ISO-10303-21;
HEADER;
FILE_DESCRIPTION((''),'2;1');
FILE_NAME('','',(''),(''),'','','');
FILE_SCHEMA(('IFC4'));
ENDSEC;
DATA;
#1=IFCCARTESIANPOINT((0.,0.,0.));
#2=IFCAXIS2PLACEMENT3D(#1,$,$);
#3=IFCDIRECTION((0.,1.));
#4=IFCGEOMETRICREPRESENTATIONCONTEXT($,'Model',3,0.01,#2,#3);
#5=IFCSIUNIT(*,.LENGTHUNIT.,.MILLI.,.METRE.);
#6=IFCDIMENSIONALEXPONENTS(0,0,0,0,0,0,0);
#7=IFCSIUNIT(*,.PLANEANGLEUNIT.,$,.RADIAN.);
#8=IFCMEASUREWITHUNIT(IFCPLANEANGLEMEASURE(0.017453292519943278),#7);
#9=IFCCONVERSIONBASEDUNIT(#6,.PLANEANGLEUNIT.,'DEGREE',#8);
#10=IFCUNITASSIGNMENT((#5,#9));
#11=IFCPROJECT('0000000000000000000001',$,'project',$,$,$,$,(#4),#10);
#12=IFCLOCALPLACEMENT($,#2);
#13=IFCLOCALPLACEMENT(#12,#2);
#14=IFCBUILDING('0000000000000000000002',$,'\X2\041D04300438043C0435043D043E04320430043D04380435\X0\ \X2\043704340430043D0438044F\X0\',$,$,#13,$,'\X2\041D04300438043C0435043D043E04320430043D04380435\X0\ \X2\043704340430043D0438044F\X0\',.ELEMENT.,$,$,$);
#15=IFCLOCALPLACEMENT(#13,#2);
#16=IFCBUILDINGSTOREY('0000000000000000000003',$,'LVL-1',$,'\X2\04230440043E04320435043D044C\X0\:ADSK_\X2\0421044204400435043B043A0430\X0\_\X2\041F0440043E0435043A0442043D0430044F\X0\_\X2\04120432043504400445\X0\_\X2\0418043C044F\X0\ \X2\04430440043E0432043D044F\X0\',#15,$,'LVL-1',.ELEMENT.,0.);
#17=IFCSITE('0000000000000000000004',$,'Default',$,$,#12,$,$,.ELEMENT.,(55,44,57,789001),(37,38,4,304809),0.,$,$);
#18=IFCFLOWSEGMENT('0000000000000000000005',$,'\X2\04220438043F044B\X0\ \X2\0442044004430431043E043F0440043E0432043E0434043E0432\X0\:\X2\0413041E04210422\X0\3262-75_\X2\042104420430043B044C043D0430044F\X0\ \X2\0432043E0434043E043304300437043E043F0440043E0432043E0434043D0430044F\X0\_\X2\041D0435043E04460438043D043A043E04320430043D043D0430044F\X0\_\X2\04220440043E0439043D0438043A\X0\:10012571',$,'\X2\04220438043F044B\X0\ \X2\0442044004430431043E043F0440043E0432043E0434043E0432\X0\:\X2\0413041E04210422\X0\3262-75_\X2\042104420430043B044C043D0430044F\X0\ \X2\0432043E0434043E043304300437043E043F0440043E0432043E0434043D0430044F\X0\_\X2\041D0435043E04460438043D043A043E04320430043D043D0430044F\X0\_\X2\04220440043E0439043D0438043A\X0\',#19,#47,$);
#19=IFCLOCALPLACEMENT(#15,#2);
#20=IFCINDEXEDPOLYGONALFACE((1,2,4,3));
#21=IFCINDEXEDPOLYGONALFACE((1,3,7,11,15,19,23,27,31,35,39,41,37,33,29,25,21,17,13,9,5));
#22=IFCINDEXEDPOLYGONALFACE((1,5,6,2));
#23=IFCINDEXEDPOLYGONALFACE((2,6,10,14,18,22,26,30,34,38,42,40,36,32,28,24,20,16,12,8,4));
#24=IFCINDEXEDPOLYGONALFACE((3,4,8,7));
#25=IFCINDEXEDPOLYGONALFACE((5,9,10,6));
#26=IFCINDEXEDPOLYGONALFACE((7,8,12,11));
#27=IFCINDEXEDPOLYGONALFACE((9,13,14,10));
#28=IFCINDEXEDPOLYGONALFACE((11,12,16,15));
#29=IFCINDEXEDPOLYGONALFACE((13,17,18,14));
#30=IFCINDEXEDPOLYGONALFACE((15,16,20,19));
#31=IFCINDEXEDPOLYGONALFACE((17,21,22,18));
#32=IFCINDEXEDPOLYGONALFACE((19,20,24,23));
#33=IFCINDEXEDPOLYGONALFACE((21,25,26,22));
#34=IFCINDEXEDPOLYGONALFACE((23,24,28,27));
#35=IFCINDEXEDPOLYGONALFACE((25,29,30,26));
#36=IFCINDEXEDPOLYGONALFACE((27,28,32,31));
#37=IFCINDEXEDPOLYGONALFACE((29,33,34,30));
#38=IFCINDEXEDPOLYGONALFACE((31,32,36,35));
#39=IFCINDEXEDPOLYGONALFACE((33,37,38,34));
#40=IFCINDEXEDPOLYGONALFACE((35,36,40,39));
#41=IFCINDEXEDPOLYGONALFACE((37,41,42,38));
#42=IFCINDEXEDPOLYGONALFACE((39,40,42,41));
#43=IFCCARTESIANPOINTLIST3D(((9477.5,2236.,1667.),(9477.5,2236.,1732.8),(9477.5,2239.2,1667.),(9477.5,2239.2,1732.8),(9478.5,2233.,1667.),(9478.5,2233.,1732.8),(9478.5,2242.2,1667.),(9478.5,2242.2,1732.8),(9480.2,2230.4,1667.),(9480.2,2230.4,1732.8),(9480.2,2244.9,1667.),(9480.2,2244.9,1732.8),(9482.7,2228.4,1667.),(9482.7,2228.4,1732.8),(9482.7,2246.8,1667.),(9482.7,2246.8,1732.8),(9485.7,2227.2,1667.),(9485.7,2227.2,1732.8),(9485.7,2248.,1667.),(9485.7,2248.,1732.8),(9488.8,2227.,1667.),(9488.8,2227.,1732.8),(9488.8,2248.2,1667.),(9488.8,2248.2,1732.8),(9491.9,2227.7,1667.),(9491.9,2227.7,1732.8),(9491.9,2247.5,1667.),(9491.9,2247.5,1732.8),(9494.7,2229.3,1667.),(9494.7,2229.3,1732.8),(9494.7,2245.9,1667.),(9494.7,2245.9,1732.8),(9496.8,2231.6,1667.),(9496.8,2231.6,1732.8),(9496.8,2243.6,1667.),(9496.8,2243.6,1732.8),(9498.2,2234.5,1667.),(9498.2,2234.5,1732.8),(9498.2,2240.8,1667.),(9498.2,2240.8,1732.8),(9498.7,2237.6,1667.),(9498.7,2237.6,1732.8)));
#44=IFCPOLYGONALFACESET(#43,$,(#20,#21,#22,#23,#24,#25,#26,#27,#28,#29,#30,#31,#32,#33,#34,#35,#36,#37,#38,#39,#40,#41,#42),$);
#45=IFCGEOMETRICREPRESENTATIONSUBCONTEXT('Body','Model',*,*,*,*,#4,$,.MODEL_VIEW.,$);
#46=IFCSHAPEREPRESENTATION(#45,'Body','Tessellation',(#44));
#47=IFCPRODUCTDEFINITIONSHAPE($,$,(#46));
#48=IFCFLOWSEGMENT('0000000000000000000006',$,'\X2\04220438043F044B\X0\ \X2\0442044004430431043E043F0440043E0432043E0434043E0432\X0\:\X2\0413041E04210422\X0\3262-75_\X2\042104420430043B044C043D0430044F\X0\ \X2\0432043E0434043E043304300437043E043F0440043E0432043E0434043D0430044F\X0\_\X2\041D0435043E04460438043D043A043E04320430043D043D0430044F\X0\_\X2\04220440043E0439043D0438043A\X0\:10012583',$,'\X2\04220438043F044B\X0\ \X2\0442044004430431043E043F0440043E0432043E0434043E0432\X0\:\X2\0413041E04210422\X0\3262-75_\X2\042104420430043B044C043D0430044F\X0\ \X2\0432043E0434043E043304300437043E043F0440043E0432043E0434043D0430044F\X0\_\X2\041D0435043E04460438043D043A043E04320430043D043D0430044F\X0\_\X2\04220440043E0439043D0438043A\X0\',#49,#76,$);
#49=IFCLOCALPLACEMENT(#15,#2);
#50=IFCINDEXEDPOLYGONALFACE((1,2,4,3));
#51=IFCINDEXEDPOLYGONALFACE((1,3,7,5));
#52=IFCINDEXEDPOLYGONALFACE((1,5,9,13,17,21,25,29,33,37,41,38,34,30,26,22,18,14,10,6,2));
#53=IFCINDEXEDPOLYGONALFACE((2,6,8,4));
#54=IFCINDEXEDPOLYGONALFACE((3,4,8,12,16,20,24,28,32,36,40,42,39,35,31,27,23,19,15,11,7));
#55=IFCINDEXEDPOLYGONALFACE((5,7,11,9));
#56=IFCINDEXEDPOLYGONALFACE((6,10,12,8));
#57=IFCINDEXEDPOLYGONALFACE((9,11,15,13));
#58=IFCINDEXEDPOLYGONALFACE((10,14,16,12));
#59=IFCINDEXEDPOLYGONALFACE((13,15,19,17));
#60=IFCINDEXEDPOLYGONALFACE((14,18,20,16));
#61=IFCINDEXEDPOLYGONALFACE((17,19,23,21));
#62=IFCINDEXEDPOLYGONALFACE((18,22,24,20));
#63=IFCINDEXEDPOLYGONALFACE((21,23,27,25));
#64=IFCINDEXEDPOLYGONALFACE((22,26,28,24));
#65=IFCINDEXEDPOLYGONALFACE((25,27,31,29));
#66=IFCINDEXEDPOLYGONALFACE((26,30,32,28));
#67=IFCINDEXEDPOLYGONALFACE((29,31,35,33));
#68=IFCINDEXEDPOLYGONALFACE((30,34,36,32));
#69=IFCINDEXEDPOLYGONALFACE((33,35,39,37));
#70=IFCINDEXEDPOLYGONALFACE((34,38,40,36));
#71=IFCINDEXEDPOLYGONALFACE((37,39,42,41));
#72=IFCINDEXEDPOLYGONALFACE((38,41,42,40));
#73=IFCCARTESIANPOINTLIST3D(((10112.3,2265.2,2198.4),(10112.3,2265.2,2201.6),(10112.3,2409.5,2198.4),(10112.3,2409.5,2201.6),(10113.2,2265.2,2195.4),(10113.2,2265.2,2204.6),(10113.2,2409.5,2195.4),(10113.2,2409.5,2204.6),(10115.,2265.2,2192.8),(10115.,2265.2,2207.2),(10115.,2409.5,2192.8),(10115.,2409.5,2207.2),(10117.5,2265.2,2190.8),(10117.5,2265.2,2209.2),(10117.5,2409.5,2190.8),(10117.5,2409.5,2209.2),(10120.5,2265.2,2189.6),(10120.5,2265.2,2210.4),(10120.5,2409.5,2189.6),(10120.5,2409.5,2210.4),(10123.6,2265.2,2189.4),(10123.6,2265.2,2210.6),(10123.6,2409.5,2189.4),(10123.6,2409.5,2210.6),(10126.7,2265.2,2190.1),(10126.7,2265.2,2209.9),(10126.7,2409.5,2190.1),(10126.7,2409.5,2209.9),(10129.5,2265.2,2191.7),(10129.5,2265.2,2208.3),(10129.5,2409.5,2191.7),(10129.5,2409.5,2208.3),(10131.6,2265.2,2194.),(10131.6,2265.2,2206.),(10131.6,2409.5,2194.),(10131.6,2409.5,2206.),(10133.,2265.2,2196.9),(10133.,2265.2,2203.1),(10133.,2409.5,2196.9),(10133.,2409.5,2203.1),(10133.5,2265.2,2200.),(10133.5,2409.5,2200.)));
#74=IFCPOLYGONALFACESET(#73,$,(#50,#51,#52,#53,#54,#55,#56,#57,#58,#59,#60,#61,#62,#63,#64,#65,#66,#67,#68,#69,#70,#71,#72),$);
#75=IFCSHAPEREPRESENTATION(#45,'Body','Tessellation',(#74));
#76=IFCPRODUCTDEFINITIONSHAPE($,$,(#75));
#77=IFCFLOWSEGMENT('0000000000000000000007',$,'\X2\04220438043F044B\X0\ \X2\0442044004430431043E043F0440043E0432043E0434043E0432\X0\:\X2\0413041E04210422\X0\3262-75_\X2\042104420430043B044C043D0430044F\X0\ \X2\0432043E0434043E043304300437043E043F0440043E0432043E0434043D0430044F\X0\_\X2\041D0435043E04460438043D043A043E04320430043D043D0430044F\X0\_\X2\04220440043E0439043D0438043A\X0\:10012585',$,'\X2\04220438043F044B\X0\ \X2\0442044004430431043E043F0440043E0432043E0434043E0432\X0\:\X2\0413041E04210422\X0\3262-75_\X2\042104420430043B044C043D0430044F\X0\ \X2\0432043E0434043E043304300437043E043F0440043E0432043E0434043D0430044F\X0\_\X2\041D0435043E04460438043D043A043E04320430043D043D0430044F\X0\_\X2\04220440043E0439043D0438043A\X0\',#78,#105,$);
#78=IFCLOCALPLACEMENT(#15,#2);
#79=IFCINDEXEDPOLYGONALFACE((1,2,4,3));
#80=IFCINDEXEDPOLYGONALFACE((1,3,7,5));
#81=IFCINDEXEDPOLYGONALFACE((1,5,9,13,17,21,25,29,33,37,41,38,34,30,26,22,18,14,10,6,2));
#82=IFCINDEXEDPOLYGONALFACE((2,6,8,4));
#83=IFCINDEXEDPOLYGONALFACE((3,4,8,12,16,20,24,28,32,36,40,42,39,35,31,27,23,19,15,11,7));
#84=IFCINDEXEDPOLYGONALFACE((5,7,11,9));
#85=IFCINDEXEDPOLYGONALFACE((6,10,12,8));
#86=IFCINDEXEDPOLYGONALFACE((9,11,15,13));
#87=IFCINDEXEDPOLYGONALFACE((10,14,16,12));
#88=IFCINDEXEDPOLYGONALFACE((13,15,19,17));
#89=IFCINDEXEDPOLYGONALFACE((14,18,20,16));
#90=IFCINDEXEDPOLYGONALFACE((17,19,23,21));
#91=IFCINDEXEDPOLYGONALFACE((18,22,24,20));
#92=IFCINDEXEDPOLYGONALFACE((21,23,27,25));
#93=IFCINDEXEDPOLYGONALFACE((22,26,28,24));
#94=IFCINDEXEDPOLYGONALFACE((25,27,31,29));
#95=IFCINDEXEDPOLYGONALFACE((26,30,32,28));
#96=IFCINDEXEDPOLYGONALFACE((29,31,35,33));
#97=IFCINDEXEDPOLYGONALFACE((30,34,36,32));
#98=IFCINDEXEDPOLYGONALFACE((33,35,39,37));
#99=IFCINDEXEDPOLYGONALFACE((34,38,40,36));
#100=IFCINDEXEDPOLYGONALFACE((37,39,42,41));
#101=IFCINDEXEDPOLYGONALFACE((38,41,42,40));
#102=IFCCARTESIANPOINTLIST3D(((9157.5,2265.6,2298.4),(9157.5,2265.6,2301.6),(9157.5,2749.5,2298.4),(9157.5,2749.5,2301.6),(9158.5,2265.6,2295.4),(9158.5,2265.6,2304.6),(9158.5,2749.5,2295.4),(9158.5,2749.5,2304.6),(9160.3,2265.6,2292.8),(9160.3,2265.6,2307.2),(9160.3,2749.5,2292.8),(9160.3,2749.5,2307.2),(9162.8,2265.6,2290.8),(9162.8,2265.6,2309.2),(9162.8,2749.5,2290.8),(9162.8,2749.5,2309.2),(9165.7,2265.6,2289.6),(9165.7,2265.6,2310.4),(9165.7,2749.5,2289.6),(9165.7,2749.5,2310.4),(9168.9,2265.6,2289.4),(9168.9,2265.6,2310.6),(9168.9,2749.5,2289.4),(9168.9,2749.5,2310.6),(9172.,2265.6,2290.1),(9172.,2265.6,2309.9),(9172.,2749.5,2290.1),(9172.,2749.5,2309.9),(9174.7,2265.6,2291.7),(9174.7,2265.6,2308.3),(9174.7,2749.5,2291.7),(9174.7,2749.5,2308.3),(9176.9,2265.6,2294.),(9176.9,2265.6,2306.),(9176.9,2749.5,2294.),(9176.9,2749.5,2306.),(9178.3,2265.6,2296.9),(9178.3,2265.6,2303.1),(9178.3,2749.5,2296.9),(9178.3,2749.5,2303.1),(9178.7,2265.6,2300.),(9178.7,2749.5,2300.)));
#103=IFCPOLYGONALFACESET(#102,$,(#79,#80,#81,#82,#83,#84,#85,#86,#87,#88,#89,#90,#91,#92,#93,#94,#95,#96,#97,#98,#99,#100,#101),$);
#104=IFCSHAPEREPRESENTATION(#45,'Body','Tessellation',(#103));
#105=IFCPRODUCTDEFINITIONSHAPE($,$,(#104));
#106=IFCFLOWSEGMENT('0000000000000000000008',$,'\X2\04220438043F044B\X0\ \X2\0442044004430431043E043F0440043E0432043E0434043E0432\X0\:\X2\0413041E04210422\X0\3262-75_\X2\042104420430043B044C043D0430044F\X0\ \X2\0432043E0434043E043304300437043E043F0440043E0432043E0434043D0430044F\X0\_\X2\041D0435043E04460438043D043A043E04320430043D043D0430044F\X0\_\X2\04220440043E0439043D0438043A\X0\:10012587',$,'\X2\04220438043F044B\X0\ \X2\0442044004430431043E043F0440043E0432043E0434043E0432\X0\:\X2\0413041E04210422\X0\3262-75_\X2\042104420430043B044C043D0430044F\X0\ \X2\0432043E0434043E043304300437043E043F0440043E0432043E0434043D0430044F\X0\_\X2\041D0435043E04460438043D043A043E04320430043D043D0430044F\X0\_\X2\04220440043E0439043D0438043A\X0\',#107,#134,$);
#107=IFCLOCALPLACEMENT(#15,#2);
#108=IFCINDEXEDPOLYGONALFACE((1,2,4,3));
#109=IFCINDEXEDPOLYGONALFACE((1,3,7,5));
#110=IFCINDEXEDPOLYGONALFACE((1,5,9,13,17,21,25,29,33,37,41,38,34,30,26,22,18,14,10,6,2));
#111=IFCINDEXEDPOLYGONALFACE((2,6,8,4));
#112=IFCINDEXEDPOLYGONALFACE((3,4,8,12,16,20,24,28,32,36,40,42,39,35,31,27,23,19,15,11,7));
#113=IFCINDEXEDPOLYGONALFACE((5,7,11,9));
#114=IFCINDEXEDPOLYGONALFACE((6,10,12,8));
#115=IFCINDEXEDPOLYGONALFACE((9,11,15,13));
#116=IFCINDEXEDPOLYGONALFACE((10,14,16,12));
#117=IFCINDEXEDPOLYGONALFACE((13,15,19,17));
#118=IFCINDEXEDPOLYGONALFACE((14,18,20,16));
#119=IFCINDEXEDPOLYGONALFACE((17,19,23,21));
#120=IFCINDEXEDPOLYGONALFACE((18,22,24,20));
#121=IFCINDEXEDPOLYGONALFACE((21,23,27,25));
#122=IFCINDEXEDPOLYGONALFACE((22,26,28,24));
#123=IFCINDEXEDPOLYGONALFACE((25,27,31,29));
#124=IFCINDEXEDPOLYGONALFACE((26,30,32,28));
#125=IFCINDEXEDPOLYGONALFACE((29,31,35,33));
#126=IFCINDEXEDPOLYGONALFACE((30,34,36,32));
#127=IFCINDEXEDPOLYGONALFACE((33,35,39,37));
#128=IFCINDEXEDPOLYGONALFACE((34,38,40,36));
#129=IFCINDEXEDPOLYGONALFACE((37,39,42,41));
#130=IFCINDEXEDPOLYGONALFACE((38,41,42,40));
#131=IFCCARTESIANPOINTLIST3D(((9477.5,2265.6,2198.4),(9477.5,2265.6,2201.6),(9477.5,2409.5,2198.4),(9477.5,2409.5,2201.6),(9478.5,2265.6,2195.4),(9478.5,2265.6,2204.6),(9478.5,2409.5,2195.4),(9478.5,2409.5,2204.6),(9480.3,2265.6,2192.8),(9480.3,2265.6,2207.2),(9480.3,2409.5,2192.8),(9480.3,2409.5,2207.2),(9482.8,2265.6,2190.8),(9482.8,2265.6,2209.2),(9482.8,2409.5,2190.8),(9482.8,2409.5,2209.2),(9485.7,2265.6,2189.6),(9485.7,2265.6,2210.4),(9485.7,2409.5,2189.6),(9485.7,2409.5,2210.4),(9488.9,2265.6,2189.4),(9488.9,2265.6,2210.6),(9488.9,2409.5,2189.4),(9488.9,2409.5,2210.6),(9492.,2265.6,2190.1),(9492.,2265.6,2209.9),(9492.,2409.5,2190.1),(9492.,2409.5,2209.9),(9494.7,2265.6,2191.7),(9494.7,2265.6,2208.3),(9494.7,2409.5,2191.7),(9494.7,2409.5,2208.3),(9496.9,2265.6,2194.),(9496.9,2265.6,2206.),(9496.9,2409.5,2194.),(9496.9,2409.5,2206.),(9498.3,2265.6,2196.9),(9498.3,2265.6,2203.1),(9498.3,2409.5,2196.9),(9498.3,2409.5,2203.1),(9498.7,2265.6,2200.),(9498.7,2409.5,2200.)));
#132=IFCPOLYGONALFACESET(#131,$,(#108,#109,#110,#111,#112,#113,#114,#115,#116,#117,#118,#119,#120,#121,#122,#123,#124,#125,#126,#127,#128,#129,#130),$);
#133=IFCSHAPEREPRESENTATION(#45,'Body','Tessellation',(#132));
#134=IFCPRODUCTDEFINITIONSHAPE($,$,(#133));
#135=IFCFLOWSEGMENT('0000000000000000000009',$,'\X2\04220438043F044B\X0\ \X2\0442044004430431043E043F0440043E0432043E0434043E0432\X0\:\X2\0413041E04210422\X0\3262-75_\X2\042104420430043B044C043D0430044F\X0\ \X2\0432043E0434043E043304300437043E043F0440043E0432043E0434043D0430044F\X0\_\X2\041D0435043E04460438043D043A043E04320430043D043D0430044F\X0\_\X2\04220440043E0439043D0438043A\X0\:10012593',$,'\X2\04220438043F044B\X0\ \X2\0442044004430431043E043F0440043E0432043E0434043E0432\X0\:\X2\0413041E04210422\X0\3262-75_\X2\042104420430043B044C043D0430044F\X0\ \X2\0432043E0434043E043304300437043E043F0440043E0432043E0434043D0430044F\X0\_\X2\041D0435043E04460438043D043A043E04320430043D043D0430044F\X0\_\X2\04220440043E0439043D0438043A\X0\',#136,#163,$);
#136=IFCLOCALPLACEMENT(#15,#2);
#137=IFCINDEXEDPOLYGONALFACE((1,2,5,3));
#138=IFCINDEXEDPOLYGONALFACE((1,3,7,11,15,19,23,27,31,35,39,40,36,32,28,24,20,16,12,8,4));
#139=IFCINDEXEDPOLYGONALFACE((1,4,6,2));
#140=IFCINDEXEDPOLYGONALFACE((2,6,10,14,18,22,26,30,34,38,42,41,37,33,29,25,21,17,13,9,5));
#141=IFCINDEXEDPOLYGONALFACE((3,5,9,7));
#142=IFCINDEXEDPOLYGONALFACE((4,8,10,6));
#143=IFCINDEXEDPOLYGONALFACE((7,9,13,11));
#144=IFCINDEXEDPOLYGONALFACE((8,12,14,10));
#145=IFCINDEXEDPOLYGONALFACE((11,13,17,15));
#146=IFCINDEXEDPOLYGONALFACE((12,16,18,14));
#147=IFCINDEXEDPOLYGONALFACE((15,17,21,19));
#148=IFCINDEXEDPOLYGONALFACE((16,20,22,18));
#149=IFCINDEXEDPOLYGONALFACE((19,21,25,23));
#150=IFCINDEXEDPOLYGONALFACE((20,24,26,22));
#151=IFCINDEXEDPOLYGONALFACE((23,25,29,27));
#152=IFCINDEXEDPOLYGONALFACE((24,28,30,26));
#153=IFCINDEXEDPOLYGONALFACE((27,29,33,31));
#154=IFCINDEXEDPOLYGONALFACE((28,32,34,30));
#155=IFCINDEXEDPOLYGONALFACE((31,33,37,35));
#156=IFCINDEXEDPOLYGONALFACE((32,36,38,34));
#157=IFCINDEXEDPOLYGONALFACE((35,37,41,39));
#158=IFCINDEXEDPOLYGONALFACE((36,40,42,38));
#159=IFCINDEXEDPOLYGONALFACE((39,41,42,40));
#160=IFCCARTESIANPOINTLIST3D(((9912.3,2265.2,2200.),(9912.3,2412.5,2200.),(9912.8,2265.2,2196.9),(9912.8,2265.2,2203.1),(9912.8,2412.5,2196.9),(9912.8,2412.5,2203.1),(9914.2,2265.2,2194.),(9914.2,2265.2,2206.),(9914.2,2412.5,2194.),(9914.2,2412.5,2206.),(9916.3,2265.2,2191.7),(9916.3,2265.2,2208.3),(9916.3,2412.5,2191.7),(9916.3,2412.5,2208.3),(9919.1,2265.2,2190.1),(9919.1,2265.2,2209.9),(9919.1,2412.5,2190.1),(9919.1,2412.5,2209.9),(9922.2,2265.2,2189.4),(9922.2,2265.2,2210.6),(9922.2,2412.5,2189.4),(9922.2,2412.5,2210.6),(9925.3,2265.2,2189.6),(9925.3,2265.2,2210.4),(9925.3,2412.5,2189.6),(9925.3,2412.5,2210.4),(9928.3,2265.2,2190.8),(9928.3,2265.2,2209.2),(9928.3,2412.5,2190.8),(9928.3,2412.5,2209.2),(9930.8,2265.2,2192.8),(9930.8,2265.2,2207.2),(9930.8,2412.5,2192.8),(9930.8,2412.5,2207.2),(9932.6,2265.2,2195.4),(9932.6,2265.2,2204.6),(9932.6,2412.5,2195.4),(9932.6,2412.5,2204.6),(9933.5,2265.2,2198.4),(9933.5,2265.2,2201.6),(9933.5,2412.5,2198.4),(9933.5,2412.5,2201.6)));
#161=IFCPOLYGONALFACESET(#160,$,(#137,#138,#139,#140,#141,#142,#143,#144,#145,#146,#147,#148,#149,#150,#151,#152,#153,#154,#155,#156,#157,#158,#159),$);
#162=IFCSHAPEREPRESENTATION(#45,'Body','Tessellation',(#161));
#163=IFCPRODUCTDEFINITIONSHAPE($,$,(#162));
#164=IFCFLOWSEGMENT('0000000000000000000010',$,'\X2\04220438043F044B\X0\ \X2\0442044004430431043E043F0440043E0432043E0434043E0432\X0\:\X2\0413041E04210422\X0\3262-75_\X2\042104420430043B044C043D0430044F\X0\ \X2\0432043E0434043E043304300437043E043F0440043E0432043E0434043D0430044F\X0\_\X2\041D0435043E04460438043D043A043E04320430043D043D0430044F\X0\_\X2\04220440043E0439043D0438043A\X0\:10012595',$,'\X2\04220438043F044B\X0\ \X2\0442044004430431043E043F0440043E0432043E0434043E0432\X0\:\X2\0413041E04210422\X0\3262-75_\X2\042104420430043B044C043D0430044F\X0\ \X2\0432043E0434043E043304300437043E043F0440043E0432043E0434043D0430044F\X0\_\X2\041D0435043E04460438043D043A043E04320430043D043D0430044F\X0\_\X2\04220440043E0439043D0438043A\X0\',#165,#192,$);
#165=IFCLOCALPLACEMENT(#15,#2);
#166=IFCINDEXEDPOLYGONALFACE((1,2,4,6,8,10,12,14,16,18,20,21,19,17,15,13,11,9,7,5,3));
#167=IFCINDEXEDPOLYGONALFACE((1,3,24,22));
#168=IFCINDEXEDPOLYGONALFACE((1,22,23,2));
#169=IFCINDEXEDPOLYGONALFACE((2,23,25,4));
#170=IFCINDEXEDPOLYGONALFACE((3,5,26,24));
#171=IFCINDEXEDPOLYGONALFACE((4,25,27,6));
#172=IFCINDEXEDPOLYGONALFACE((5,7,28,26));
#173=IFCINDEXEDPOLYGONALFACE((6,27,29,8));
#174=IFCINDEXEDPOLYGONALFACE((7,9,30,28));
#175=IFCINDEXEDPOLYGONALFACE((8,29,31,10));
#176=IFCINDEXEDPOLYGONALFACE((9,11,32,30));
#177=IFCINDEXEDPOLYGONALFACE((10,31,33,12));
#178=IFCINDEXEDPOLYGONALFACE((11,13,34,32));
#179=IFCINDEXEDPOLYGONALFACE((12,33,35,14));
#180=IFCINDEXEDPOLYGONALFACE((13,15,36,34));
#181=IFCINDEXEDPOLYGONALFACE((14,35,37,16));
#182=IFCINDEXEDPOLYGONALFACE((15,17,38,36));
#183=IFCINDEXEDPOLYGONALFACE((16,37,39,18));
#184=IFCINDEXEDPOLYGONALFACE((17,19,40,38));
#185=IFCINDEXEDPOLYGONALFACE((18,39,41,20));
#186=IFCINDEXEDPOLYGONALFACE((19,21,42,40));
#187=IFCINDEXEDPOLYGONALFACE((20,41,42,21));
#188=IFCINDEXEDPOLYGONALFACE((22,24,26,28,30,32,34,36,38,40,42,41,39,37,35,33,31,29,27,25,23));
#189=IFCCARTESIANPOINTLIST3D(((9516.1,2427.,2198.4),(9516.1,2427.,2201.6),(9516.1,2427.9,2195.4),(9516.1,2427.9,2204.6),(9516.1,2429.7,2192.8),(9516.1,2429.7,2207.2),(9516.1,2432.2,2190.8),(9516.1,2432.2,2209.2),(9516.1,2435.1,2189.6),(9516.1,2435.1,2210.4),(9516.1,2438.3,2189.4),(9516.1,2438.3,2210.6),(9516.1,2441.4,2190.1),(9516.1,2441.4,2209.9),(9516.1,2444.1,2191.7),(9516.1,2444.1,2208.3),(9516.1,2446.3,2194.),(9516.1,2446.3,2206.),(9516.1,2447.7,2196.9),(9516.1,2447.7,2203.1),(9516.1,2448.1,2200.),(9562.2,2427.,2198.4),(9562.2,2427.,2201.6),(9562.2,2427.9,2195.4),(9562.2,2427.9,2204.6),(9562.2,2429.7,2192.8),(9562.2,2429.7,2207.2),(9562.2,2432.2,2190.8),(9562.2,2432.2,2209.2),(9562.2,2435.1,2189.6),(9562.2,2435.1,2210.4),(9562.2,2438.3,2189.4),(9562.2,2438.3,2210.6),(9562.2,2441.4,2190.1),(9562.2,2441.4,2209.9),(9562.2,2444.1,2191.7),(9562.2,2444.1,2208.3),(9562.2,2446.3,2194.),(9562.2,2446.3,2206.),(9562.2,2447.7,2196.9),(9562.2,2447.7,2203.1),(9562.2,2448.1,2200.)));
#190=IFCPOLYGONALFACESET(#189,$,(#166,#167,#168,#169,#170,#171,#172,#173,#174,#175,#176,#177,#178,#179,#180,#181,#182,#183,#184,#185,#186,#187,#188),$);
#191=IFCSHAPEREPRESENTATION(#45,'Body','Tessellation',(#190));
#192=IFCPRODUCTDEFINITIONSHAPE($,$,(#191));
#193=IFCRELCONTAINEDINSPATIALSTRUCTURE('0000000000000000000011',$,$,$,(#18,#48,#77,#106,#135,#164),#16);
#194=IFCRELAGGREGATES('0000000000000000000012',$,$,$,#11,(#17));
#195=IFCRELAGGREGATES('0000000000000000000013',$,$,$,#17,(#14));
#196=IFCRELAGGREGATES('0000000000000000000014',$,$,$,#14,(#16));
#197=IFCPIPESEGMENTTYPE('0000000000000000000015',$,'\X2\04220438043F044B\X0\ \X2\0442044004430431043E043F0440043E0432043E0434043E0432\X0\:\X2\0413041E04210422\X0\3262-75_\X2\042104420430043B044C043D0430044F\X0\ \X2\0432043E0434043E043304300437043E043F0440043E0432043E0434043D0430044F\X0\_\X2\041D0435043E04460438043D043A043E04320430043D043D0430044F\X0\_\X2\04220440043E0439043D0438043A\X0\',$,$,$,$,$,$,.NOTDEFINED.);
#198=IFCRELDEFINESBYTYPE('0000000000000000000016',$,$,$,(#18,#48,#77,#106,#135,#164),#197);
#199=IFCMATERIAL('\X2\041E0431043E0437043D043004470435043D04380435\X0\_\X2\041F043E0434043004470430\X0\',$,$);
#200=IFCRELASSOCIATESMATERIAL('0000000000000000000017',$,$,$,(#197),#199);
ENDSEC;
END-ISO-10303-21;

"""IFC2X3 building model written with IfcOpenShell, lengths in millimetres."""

from ifc_helpers import new_model, entity, si_unit, converted_unit, direction, frame, frame_2d, origin, origin_2d_with_axis, place, context, subcontext, project, spatial, circle, extrude, material, type_object, element, save


model = new_model("IFC2X3")

# Units and contexts
model_context = context("Model", 3, precision=0.01, world=origin(), true_north=direction((0.0, 1.0)))
body_context = subcontext(model_context, "Body", "Model", "MODEL_VIEW")
ifc_project = project(units=[si_unit("LENGTHUNIT", "METRE", prefix="MILLI"), converted_unit("PLANEANGLEUNIT", "DEGREE", entity("IfcPlaneAngleMeasure", 0.017453292519943278), si_unit("PLANEANGLEUNIT", "RADIAN"), dimensions=[0, 0, 0, 0, 0, 0, 0])], contexts=[model_context])

# Site, building, storey
site_placement = place(None, origin())
site = spatial("IfcSite", under=ifc_project, at=site_placement, Name="Default", CompositionType="ELEMENT", RefLatitude=(55, 44, 57, 789001), RefLongitude=(37, 38, 4, 304809), RefElevation=0.0)
building_placement = place(site_placement, origin())
building = spatial("IfcBuilding", under=site, at=building_placement, Name="Наименование здания", LongName="Наименование здания", CompositionType="ELEMENT")
storey_placement = place(building_placement, origin())
storey = spatial("IfcBuildingStorey", under=building, at=storey_placement, Name="LVL-1", ObjectType="Уровень:ADSK_Стрелка_Проектная_Вверх_Имя уровня", LongName="LVL-1", CompositionType="ELEMENT", Elevation=0.0)

# Flow segments
ifc_material_1 = material(Name="Обозначение_Подача")
pipe_segment_type_1 = type_object("IfcPipeSegmentType", Name="Типы трубопроводов:ГОСТ3262-75_Стальная водогазопроводная_Неоцинкованная_Тройник", PredefinedType="NOTDEFINED", material=ifc_material_1)
flow_segment_1_placement = place(storey_placement, origin())
element("IfcFlowSegment", 1, at=flow_segment_1_placement, inside=storey, type_object=pipe_segment_type_1, Name="Типы трубопроводов:ГОСТ3262-75_Стальная водогазопроводная_Неоцинкованная_Тройник:10012571", ObjectType="Типы трубопроводов:ГОСТ3262-75_Стальная водогазопроводная_Неоцинкованная_Тройник", context=body_context, shape_type="SweptSolid", body=[
    extrude(circle(Radius=10.7, at=origin_2d_with_axis()), frame((9488.0, 2237.6, 1667.0)), (0.0, 0.0, 1.0), 65.8),
])
flow_segment_2_placement = place(storey_placement, origin())
element("IfcFlowSegment", 2, at=flow_segment_2_placement, inside=storey, type_object=pipe_segment_type_1, Name="Типы трубопроводов:ГОСТ3262-75_Стальная водогазопроводная_Неоцинкованная_Тройник:10012583", ObjectType="Типы трубопроводов:ГОСТ3262-75_Стальная водогазопроводная_Неоцинкованная_Тройник", context=body_context, shape_type="SweptSolid", body=[
    extrude(circle(Radius=10.7, at=frame_2d((0.0, 0.0), x_axis=(1.0, 0.0))), frame((10122.8, 2265.2, 2200.0), z_axis=(0.0, 1.0, 0.0), x_axis=(1.0, 0.0, 0.0)), (0.0, 0.0, 1.0), 144.3),
])
flow_segment_3_placement = place(storey_placement, origin())
element("IfcFlowSegment", 3, at=flow_segment_3_placement, inside=storey, type_object=pipe_segment_type_1, Name="Типы трубопроводов:ГОСТ3262-75_Стальная водогазопроводная_Неоцинкованная_Тройник:10012585", ObjectType="Типы трубопроводов:ГОСТ3262-75_Стальная водогазопроводная_Неоцинкованная_Тройник", context=body_context, shape_type="SweptSolid", body=[
    extrude(circle(Radius=10.7, at=origin_2d_with_axis()), frame((9168.1, 2265.6, 2300.0), z_axis=(0.0, 1.0, 0.0), x_axis=(1.0, 0.0, 0.0)), (0.0, 0.0, 1.0), 483.9),
])
flow_segment_4_placement = place(storey_placement, origin())
element("IfcFlowSegment", 4, at=flow_segment_4_placement, inside=storey, type_object=pipe_segment_type_1, Name="Типы трубопроводов:ГОСТ3262-75_Стальная водогазопроводная_Неоцинкованная_Тройник:10012587", ObjectType="Типы трубопроводов:ГОСТ3262-75_Стальная водогазопроводная_Неоцинкованная_Тройник", context=body_context, shape_type="SweptSolid", body=[
    extrude(circle(Radius=10.7, at=origin_2d_with_axis()), frame((9488.1, 2265.6, 2200.0), z_axis=(0.0, 1.0, 0.0), x_axis=(1.0, 0.0, 0.0)), (0.0, 0.0, 1.0), 143.9),
])
flow_segment_5_placement = place(storey_placement, origin())
element("IfcFlowSegment", 5, at=flow_segment_5_placement, inside=storey, type_object=pipe_segment_type_1, Name="Типы трубопроводов:ГОСТ3262-75_Стальная водогазопроводная_Неоцинкованная_Тройник:10012593", ObjectType="Типы трубопроводов:ГОСТ3262-75_Стальная водогазопроводная_Неоцинкованная_Тройник", context=body_context, shape_type="SweptSolid", body=[
    extrude(circle(Radius=10.7, at=origin_2d_with_axis()), frame((9923.0, 2265.2, 2200.0), z_axis=(0.0, 1.0, 0.0), x_axis=(-1.0, 0.0, 0.0)), (0.0, 0.0, 1.0), 147.3),
])
flow_segment_6_placement = place(storey_placement, origin())
element("IfcFlowSegment", 6, at=flow_segment_6_placement, inside=storey, type_object=pipe_segment_type_1, Name="Типы трубопроводов:ГОСТ3262-75_Стальная водогазопроводная_Неоцинкованная_Тройник:10012595", ObjectType="Типы трубопроводов:ГОСТ3262-75_Стальная водогазопроводная_Неоцинкованная_Тройник", context=body_context, shape_type="SweptSolid", body=[
    extrude(circle(Radius=10.7, at=frame_2d((0.0, 0.0), x_axis=(1.0, 0.0))), frame((9516.1, 2437.5, 2200.0), z_axis=(1.0, 0.0, 0.0), x_axis=(0.0, 1.0, 0.0)), (0.0, 0.0, 1.0), 46.1),
])

save(model, "model.ifc")
